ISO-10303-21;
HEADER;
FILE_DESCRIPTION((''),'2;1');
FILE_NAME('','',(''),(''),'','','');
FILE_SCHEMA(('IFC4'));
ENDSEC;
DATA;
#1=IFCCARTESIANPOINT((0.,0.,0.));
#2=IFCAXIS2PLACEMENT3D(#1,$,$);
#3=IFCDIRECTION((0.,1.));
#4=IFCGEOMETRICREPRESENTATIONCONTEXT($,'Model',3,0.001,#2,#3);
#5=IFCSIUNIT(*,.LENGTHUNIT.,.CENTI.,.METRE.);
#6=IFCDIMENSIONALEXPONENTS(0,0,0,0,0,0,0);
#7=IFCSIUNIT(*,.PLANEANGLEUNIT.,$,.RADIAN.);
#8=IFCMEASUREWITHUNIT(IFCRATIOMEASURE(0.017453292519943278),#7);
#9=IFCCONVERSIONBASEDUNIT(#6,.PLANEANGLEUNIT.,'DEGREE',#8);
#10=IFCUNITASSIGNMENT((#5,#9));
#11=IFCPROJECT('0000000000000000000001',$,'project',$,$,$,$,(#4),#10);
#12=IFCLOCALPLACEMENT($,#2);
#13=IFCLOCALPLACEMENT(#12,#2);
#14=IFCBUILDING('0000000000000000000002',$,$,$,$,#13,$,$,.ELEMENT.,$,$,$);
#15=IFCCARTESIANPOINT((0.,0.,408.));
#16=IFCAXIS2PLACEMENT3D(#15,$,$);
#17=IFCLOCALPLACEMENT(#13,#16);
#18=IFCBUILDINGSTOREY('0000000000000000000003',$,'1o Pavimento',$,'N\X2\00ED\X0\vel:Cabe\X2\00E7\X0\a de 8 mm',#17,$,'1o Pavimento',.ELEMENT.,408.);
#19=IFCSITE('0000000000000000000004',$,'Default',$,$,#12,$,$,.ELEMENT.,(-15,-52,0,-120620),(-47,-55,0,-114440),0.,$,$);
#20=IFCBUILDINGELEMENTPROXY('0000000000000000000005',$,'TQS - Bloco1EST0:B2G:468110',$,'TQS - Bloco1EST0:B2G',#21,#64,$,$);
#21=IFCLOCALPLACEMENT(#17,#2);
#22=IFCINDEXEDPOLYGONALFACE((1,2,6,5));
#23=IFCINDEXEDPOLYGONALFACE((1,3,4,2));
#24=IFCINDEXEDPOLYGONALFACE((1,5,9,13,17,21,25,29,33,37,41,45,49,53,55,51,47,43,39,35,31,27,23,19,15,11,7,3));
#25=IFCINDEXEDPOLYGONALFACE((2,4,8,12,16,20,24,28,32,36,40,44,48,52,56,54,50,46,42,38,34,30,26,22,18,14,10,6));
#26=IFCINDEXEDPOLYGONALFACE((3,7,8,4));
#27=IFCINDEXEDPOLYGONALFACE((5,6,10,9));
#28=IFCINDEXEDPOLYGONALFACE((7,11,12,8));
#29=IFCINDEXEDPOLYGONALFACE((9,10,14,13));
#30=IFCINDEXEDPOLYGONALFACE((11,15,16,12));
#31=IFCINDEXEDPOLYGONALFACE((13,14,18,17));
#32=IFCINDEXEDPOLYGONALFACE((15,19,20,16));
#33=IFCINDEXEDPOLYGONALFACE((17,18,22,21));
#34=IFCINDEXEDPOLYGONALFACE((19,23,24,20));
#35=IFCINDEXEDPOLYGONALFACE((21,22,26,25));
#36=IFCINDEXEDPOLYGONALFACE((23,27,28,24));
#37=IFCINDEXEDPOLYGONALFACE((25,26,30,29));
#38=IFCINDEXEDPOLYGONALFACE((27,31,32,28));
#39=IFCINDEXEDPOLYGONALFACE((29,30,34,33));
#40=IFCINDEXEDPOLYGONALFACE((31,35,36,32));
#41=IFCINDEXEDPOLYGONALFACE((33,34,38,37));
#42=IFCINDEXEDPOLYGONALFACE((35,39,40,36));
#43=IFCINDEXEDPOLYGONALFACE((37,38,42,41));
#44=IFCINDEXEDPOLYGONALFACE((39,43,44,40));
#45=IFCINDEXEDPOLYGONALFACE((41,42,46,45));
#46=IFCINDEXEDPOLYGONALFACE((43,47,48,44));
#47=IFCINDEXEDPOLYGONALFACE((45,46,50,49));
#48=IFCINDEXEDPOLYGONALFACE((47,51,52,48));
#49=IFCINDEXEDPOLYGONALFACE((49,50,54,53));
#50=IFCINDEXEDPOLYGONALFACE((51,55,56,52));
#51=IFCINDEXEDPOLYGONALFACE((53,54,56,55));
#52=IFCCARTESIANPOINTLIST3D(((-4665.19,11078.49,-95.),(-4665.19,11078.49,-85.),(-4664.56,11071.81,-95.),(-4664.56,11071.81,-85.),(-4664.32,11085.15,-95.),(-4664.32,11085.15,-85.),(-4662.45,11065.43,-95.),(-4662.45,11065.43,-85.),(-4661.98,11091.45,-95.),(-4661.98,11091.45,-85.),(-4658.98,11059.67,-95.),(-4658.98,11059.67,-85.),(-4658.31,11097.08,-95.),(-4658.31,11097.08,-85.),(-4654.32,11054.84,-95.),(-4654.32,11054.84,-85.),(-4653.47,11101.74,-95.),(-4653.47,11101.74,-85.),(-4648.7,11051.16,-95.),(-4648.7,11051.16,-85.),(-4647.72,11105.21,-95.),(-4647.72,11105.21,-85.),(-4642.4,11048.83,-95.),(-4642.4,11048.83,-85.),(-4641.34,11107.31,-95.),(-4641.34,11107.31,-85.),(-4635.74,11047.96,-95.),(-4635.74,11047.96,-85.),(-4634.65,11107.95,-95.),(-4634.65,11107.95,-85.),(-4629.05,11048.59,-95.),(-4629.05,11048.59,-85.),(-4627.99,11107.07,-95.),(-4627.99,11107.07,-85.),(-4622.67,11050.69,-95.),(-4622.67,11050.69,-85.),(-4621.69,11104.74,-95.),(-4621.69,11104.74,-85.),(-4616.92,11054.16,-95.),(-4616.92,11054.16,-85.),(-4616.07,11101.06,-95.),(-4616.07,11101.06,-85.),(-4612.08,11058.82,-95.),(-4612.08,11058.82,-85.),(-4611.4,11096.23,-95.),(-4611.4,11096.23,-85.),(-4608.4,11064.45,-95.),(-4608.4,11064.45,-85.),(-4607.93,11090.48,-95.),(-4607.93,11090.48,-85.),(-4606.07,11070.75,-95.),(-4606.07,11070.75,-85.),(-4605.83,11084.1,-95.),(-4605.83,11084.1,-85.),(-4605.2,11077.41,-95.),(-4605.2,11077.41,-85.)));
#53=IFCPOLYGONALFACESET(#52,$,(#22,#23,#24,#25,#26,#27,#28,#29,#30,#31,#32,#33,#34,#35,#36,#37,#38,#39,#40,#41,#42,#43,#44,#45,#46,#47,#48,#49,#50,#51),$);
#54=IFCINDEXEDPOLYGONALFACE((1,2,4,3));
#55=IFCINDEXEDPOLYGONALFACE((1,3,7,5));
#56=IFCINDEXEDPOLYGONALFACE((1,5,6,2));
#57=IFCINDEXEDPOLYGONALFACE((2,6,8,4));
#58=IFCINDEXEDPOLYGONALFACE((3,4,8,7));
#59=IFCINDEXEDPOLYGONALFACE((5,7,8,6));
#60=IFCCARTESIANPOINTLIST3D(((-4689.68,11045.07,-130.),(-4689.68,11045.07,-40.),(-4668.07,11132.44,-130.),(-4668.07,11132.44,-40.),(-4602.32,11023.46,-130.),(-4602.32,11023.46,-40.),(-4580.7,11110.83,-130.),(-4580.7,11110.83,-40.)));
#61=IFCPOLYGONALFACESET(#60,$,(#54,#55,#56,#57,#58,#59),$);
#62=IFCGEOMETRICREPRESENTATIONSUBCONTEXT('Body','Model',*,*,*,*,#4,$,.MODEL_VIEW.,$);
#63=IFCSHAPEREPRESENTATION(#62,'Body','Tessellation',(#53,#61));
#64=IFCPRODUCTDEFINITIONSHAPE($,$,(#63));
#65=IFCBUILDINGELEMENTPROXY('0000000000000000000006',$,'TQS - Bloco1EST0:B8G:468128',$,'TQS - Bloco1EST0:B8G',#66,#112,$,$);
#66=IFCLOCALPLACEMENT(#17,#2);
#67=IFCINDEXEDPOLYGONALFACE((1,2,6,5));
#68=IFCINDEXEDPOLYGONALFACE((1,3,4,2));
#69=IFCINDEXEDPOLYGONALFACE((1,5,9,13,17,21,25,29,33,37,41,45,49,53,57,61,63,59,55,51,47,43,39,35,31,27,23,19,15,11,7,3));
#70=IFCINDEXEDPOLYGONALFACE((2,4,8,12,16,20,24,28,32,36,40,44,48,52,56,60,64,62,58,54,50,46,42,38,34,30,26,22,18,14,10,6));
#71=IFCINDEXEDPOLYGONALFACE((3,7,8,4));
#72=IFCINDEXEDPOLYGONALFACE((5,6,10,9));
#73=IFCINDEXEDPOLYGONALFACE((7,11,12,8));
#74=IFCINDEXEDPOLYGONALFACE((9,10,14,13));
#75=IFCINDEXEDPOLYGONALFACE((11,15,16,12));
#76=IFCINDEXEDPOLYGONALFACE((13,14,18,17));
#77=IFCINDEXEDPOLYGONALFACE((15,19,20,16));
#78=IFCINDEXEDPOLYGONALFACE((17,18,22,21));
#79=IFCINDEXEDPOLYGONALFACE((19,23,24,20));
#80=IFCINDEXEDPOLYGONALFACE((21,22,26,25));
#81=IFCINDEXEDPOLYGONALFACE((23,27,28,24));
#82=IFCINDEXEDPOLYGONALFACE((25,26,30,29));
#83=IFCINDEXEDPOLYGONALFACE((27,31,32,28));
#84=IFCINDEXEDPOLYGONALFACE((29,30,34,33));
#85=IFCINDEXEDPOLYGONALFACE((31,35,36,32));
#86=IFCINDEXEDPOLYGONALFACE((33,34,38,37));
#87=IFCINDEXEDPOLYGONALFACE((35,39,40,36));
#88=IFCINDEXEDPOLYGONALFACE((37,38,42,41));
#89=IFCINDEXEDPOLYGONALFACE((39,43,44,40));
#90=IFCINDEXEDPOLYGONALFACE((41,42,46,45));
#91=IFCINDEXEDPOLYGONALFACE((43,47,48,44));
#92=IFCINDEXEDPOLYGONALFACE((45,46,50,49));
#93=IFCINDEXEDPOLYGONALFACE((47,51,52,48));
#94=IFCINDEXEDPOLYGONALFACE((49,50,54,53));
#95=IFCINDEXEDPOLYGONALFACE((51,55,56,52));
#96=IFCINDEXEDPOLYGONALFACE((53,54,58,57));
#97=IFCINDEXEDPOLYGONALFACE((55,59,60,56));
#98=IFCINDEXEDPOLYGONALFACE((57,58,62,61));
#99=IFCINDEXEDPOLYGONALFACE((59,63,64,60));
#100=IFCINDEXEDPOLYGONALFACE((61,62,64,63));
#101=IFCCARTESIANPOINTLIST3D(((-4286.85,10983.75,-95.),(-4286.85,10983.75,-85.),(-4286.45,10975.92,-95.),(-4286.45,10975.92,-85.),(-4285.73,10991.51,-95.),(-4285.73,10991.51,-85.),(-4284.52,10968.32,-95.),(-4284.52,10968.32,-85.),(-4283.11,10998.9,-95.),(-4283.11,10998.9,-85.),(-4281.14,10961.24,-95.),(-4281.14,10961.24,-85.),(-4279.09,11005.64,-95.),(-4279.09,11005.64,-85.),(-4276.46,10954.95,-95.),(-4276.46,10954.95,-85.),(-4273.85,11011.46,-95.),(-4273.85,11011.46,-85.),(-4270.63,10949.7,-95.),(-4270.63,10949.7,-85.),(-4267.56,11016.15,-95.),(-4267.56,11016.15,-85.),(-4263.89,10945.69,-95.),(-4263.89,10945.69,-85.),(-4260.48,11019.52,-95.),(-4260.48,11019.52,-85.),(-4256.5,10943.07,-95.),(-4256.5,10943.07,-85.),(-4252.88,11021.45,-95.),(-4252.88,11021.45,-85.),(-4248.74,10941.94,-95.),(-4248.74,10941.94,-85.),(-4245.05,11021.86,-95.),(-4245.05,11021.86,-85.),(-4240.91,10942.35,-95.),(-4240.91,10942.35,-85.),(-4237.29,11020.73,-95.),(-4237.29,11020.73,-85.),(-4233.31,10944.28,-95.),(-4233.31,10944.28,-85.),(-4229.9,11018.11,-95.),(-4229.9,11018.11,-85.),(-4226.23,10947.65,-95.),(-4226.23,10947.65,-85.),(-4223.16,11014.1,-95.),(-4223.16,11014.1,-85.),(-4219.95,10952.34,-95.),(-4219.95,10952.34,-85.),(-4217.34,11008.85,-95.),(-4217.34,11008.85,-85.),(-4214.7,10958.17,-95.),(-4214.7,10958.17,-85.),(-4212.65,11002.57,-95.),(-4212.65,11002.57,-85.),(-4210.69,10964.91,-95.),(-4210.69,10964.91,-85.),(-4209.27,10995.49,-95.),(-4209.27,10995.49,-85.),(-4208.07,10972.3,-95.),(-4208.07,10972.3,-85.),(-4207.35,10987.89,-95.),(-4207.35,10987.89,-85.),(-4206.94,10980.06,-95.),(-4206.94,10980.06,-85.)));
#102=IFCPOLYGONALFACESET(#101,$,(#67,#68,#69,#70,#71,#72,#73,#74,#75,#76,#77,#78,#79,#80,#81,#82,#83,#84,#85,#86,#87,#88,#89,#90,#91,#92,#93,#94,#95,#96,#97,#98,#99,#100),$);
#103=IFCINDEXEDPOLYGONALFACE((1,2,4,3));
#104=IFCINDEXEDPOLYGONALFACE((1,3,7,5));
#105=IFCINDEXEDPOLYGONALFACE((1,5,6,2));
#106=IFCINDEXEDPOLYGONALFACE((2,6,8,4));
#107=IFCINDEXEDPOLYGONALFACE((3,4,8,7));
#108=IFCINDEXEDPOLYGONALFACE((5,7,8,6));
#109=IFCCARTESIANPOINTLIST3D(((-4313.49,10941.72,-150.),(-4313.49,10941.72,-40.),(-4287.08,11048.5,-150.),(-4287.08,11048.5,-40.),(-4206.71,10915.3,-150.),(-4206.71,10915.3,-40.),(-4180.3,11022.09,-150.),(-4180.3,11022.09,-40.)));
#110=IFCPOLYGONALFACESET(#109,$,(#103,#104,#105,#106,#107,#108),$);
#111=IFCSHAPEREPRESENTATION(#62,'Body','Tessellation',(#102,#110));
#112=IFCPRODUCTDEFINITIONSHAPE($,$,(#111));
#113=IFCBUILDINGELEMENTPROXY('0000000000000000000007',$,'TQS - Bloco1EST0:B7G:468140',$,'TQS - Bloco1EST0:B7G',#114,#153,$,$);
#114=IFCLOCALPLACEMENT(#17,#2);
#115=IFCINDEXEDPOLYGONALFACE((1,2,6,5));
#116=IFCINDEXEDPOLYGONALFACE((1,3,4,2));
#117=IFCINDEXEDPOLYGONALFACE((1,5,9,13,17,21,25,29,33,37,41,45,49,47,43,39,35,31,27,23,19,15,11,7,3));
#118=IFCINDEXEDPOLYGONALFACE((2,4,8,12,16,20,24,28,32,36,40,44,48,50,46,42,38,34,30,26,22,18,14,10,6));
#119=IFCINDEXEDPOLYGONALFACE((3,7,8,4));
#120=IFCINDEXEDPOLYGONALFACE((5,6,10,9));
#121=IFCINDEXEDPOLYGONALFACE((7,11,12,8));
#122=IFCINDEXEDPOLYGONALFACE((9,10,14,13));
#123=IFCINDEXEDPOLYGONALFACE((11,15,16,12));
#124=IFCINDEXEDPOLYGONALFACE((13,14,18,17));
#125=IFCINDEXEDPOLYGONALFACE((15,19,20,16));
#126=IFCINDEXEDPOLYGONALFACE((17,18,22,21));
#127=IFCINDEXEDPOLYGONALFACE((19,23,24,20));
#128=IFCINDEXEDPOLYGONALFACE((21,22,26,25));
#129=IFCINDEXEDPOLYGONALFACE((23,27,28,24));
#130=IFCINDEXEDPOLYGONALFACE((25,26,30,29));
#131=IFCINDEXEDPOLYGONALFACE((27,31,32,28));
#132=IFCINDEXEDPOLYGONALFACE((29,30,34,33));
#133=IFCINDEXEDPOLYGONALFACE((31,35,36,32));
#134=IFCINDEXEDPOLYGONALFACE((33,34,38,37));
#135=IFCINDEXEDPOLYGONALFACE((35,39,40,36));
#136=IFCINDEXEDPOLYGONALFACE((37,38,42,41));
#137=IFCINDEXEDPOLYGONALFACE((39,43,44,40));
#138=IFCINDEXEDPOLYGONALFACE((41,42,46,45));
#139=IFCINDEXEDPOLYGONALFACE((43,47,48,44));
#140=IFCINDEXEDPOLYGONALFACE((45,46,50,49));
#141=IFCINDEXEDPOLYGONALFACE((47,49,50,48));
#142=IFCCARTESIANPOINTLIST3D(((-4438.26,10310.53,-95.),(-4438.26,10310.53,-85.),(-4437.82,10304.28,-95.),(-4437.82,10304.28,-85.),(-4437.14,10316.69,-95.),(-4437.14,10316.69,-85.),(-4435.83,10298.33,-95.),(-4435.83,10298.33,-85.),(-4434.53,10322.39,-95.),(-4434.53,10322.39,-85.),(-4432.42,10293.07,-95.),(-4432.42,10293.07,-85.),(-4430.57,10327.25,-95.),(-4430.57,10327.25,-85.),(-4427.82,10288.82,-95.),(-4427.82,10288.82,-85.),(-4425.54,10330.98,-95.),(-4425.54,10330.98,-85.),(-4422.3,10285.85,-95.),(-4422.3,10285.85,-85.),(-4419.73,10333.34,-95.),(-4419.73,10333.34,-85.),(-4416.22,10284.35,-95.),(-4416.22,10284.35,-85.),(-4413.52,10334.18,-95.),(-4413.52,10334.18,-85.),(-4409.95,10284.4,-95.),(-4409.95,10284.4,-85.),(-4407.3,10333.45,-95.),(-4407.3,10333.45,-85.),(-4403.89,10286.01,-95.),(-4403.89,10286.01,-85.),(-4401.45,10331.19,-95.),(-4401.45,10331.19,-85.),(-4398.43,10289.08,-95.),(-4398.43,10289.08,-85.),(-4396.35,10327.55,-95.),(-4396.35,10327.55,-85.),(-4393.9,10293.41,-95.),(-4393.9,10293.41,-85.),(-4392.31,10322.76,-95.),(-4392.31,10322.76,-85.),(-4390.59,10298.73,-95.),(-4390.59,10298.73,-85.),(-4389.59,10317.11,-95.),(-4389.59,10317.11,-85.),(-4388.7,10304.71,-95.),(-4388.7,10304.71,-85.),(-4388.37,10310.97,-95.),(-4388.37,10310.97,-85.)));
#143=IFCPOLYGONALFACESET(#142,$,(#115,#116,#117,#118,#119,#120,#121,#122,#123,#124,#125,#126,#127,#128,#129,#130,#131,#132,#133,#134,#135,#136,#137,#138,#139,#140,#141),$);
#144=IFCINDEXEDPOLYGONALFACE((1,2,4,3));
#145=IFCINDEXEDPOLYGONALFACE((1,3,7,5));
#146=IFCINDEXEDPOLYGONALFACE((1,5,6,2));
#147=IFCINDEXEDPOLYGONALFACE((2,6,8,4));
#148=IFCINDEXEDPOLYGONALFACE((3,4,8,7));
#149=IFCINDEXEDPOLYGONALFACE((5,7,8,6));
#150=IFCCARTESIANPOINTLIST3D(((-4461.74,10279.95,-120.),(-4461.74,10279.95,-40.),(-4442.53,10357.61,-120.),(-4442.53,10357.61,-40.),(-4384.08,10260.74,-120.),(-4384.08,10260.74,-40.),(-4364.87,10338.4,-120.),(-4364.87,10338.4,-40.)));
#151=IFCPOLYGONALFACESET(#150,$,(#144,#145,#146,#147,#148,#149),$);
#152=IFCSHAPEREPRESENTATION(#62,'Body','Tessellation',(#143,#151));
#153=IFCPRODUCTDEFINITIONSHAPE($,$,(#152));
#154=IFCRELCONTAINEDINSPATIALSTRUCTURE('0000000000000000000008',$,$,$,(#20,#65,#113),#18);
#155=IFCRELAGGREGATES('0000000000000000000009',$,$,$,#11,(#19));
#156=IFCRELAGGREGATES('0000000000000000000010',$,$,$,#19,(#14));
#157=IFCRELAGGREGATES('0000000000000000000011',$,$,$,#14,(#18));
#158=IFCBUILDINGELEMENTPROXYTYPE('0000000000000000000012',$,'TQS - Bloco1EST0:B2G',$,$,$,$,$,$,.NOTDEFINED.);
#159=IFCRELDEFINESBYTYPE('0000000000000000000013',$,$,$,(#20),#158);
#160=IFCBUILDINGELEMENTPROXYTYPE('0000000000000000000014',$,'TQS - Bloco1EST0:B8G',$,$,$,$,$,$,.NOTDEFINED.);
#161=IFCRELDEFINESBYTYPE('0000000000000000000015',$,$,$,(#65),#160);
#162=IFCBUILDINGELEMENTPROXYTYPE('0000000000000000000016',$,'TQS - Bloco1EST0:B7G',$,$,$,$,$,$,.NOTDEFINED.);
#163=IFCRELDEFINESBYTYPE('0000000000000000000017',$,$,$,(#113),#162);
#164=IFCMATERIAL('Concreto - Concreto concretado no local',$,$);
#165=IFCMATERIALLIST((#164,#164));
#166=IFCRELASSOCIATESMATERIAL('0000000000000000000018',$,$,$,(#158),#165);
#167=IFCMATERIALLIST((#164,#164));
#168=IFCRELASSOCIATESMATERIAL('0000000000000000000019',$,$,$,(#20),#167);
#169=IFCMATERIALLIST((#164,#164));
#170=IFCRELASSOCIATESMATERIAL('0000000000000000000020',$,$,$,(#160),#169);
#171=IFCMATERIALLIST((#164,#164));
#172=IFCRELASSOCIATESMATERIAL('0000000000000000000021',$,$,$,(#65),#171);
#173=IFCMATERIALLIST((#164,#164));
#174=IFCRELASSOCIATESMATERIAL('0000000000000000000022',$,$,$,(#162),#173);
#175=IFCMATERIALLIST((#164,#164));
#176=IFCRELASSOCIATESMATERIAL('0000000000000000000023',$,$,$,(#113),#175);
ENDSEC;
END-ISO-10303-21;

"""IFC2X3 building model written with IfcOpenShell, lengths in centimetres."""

from ifc_helpers import new_model, entity, si_unit, converted_unit, direction, frame, frame_2d, origin, origin_2d_with_axis, place, context, subcontext, project, spatial, rectangle, circle, extrude, source, transform, mapped, material, material_list, type_object, type_shapes, element, save


model = new_model("IFC2X3")

# Units and contexts
model_context = context("Model", 3, precision=0.001, world=origin(), true_north=direction((0.0, 1.0)))
body_context = subcontext(model_context, "Body", "Model", "MODEL_VIEW")
ifc_project = project(units=[si_unit("LENGTHUNIT", "METRE", prefix="CENTI"), converted_unit("PLANEANGLEUNIT", "DEGREE", entity("IfcRatioMeasure", 0.017453292519943278), si_unit("PLANEANGLEUNIT", "RADIAN"), dimensions=[0, 0, 0, 0, 0, 0, 0])], contexts=[model_context])

# Site, building, storey
site_placement = place(None, origin())
site = spatial("IfcSite", under=ifc_project, at=site_placement, Name="Default", CompositionType="ELEMENT", RefLatitude=(-15, -52, 0, -120620), RefLongitude=(-47, -55, 0, -114440), RefElevation=0.0)
building_placement = place(site_placement, origin())
building = spatial("IfcBuilding", under=site, at=building_placement, CompositionType="ELEMENT")
storey_placement = place(building_placement, frame((0.0, 0.0, 408.0)))
storey = spatial("IfcBuildingStorey", under=building, at=storey_placement, Name="1o Pavimento", ObjectType="Nível:Cabeça de 8 mm", LongName="1o Pavimento", CompositionType="ELEMENT", Elevation=408.0)

# Building element proxies
ifc_material_1 = material(Name="Concreto - Concreto concretado no local")
ifc_material_list_1 = material_list([ifc_material_1, ifc_material_1])
ifc_material_list_2 = material_list([ifc_material_1, ifc_material_1])
building_element_proxy_type_1 = type_object("IfcBuildingElementProxyType", Name="TQS - Bloco1EST0:B2G", PredefinedType="NOTDEFINED", material=ifc_material_list_2)
shared_shape_1 = source(origin(), body_context, "Body", "SweptSolid", [
    extrude(circle(Radius=30.0, at=frame_2d((0.0, 0.0), x_axis=(1.0, 0.0))), frame((0.0, 0.0, -55.0)), (0.0, 0.0, 1.0), 10.0),
    extrude(rectangle(XDim=90.0, YDim=90.0, at=origin_2d_with_axis()), frame((0.0, 0.0, -90.0), z_axis=(0.0, 0.0, 1.0), x_axis=(-1.0, 0.0, 0.0)), (0.0, 0.0, 1.0), 90.0),
])
type_shapes(building_element_proxy_type_1, [shared_shape_1])
proxy_1_placement = place(storey_placement, frame((-4635.19, 11077.95, -40.0), z_axis=(0.0, 0.0, 1.0), x_axis=(0.240122, 0.970743, 0.0)))
element("IfcBuildingElementProxy", 1, at=proxy_1_placement, inside=storey, type_object=building_element_proxy_type_1, material=ifc_material_list_1, Name="TQS - Bloco1EST0:B2G:468110", ObjectType="TQS - Bloco1EST0:B2G", context=body_context, shape_type="MappedRepresentation", body=[
    mapped(shared_shape_1, transform((0.0, 0.0, 0.0), scale=1.0)),
])
ifc_material_list_3 = material_list([ifc_material_1, ifc_material_1])
ifc_material_list_4 = material_list([ifc_material_1, ifc_material_1])
building_element_proxy_type_2 = type_object("IfcBuildingElementProxyType", Name="TQS - Bloco1EST0:B8G", PredefinedType="NOTDEFINED", material=ifc_material_list_4)
shared_shape_2 = source(origin(), body_context, "Body", "SweptSolid", [
    extrude(circle(Radius=40.0, at=frame_2d((0.0, 0.0), x_axis=(1.0, 0.0))), frame((0.0, 0.0, -55.0)), (0.0, 0.0, 1.0), 10.0),
    extrude(rectangle(XDim=110.0, YDim=110.0, at=origin_2d_with_axis()), frame((0.0, 0.0, -110.0), z_axis=(0.0, 0.0, 1.0), x_axis=(-1.0, 0.0, 0.0)), (0.0, 0.0, 1.0), 110.0),
])
type_shapes(building_element_proxy_type_2, [shared_shape_2])
proxy_2_placement = place(storey_placement, frame((-4246.9, 10981.9, -40.0), z_axis=(0.0, 0.0, 1.0), x_axis=(0.240122, 0.970743, 0.0)))
element("IfcBuildingElementProxy", 2, at=proxy_2_placement, inside=storey, type_object=building_element_proxy_type_2, material=ifc_material_list_3, Name="TQS - Bloco1EST0:B8G:468128", ObjectType="TQS - Bloco1EST0:B8G", context=body_context, shape_type="MappedRepresentation", body=[
    mapped(shared_shape_2, transform((0.0, 0.0, 0.0), scale=1.0)),
])
ifc_material_list_5 = material_list([ifc_material_1, ifc_material_1])
ifc_material_list_6 = material_list([ifc_material_1, ifc_material_1])
building_element_proxy_type_3 = type_object("IfcBuildingElementProxyType", Name="TQS - Bloco1EST0:B7G", PredefinedType="NOTDEFINED", material=ifc_material_list_6)
shared_shape_3 = source(origin(), body_context, "Body", "SweptSolid", [
    extrude(circle(Radius=25.0, at=frame_2d((0.0, 0.0), x_axis=(1.0, 0.0))), frame((0.0, 0.0, -55.0)), (0.0, 0.0, 1.0), 10.0),
    extrude(rectangle(XDim=80.0, YDim=80.0, at=origin_2d_with_axis()), frame((0.0, 0.0, -80.0), z_axis=(0.0, 0.0, 1.0), x_axis=(-1.0, 0.0, 0.0)), (0.0, 0.0, 1.0), 80.0),
])
type_shapes(building_element_proxy_type_3, [shared_shape_3])
proxy_3_placement = place(storey_placement, frame((-4413.3, 10309.18, -40.0), z_axis=(0.0, 0.0, 1.0), x_axis=(0.240122, 0.970743, 0.0)))
element("IfcBuildingElementProxy", 3, at=proxy_3_placement, inside=storey, type_object=building_element_proxy_type_3, material=ifc_material_list_5, Name="TQS - Bloco1EST0:B7G:468140", ObjectType="TQS - Bloco1EST0:B7G", context=body_context, shape_type="MappedRepresentation", body=[
    mapped(shared_shape_3, transform((0.0, 0.0, 0.0), scale=1.0)),
])

save(model, "model.ifc")
